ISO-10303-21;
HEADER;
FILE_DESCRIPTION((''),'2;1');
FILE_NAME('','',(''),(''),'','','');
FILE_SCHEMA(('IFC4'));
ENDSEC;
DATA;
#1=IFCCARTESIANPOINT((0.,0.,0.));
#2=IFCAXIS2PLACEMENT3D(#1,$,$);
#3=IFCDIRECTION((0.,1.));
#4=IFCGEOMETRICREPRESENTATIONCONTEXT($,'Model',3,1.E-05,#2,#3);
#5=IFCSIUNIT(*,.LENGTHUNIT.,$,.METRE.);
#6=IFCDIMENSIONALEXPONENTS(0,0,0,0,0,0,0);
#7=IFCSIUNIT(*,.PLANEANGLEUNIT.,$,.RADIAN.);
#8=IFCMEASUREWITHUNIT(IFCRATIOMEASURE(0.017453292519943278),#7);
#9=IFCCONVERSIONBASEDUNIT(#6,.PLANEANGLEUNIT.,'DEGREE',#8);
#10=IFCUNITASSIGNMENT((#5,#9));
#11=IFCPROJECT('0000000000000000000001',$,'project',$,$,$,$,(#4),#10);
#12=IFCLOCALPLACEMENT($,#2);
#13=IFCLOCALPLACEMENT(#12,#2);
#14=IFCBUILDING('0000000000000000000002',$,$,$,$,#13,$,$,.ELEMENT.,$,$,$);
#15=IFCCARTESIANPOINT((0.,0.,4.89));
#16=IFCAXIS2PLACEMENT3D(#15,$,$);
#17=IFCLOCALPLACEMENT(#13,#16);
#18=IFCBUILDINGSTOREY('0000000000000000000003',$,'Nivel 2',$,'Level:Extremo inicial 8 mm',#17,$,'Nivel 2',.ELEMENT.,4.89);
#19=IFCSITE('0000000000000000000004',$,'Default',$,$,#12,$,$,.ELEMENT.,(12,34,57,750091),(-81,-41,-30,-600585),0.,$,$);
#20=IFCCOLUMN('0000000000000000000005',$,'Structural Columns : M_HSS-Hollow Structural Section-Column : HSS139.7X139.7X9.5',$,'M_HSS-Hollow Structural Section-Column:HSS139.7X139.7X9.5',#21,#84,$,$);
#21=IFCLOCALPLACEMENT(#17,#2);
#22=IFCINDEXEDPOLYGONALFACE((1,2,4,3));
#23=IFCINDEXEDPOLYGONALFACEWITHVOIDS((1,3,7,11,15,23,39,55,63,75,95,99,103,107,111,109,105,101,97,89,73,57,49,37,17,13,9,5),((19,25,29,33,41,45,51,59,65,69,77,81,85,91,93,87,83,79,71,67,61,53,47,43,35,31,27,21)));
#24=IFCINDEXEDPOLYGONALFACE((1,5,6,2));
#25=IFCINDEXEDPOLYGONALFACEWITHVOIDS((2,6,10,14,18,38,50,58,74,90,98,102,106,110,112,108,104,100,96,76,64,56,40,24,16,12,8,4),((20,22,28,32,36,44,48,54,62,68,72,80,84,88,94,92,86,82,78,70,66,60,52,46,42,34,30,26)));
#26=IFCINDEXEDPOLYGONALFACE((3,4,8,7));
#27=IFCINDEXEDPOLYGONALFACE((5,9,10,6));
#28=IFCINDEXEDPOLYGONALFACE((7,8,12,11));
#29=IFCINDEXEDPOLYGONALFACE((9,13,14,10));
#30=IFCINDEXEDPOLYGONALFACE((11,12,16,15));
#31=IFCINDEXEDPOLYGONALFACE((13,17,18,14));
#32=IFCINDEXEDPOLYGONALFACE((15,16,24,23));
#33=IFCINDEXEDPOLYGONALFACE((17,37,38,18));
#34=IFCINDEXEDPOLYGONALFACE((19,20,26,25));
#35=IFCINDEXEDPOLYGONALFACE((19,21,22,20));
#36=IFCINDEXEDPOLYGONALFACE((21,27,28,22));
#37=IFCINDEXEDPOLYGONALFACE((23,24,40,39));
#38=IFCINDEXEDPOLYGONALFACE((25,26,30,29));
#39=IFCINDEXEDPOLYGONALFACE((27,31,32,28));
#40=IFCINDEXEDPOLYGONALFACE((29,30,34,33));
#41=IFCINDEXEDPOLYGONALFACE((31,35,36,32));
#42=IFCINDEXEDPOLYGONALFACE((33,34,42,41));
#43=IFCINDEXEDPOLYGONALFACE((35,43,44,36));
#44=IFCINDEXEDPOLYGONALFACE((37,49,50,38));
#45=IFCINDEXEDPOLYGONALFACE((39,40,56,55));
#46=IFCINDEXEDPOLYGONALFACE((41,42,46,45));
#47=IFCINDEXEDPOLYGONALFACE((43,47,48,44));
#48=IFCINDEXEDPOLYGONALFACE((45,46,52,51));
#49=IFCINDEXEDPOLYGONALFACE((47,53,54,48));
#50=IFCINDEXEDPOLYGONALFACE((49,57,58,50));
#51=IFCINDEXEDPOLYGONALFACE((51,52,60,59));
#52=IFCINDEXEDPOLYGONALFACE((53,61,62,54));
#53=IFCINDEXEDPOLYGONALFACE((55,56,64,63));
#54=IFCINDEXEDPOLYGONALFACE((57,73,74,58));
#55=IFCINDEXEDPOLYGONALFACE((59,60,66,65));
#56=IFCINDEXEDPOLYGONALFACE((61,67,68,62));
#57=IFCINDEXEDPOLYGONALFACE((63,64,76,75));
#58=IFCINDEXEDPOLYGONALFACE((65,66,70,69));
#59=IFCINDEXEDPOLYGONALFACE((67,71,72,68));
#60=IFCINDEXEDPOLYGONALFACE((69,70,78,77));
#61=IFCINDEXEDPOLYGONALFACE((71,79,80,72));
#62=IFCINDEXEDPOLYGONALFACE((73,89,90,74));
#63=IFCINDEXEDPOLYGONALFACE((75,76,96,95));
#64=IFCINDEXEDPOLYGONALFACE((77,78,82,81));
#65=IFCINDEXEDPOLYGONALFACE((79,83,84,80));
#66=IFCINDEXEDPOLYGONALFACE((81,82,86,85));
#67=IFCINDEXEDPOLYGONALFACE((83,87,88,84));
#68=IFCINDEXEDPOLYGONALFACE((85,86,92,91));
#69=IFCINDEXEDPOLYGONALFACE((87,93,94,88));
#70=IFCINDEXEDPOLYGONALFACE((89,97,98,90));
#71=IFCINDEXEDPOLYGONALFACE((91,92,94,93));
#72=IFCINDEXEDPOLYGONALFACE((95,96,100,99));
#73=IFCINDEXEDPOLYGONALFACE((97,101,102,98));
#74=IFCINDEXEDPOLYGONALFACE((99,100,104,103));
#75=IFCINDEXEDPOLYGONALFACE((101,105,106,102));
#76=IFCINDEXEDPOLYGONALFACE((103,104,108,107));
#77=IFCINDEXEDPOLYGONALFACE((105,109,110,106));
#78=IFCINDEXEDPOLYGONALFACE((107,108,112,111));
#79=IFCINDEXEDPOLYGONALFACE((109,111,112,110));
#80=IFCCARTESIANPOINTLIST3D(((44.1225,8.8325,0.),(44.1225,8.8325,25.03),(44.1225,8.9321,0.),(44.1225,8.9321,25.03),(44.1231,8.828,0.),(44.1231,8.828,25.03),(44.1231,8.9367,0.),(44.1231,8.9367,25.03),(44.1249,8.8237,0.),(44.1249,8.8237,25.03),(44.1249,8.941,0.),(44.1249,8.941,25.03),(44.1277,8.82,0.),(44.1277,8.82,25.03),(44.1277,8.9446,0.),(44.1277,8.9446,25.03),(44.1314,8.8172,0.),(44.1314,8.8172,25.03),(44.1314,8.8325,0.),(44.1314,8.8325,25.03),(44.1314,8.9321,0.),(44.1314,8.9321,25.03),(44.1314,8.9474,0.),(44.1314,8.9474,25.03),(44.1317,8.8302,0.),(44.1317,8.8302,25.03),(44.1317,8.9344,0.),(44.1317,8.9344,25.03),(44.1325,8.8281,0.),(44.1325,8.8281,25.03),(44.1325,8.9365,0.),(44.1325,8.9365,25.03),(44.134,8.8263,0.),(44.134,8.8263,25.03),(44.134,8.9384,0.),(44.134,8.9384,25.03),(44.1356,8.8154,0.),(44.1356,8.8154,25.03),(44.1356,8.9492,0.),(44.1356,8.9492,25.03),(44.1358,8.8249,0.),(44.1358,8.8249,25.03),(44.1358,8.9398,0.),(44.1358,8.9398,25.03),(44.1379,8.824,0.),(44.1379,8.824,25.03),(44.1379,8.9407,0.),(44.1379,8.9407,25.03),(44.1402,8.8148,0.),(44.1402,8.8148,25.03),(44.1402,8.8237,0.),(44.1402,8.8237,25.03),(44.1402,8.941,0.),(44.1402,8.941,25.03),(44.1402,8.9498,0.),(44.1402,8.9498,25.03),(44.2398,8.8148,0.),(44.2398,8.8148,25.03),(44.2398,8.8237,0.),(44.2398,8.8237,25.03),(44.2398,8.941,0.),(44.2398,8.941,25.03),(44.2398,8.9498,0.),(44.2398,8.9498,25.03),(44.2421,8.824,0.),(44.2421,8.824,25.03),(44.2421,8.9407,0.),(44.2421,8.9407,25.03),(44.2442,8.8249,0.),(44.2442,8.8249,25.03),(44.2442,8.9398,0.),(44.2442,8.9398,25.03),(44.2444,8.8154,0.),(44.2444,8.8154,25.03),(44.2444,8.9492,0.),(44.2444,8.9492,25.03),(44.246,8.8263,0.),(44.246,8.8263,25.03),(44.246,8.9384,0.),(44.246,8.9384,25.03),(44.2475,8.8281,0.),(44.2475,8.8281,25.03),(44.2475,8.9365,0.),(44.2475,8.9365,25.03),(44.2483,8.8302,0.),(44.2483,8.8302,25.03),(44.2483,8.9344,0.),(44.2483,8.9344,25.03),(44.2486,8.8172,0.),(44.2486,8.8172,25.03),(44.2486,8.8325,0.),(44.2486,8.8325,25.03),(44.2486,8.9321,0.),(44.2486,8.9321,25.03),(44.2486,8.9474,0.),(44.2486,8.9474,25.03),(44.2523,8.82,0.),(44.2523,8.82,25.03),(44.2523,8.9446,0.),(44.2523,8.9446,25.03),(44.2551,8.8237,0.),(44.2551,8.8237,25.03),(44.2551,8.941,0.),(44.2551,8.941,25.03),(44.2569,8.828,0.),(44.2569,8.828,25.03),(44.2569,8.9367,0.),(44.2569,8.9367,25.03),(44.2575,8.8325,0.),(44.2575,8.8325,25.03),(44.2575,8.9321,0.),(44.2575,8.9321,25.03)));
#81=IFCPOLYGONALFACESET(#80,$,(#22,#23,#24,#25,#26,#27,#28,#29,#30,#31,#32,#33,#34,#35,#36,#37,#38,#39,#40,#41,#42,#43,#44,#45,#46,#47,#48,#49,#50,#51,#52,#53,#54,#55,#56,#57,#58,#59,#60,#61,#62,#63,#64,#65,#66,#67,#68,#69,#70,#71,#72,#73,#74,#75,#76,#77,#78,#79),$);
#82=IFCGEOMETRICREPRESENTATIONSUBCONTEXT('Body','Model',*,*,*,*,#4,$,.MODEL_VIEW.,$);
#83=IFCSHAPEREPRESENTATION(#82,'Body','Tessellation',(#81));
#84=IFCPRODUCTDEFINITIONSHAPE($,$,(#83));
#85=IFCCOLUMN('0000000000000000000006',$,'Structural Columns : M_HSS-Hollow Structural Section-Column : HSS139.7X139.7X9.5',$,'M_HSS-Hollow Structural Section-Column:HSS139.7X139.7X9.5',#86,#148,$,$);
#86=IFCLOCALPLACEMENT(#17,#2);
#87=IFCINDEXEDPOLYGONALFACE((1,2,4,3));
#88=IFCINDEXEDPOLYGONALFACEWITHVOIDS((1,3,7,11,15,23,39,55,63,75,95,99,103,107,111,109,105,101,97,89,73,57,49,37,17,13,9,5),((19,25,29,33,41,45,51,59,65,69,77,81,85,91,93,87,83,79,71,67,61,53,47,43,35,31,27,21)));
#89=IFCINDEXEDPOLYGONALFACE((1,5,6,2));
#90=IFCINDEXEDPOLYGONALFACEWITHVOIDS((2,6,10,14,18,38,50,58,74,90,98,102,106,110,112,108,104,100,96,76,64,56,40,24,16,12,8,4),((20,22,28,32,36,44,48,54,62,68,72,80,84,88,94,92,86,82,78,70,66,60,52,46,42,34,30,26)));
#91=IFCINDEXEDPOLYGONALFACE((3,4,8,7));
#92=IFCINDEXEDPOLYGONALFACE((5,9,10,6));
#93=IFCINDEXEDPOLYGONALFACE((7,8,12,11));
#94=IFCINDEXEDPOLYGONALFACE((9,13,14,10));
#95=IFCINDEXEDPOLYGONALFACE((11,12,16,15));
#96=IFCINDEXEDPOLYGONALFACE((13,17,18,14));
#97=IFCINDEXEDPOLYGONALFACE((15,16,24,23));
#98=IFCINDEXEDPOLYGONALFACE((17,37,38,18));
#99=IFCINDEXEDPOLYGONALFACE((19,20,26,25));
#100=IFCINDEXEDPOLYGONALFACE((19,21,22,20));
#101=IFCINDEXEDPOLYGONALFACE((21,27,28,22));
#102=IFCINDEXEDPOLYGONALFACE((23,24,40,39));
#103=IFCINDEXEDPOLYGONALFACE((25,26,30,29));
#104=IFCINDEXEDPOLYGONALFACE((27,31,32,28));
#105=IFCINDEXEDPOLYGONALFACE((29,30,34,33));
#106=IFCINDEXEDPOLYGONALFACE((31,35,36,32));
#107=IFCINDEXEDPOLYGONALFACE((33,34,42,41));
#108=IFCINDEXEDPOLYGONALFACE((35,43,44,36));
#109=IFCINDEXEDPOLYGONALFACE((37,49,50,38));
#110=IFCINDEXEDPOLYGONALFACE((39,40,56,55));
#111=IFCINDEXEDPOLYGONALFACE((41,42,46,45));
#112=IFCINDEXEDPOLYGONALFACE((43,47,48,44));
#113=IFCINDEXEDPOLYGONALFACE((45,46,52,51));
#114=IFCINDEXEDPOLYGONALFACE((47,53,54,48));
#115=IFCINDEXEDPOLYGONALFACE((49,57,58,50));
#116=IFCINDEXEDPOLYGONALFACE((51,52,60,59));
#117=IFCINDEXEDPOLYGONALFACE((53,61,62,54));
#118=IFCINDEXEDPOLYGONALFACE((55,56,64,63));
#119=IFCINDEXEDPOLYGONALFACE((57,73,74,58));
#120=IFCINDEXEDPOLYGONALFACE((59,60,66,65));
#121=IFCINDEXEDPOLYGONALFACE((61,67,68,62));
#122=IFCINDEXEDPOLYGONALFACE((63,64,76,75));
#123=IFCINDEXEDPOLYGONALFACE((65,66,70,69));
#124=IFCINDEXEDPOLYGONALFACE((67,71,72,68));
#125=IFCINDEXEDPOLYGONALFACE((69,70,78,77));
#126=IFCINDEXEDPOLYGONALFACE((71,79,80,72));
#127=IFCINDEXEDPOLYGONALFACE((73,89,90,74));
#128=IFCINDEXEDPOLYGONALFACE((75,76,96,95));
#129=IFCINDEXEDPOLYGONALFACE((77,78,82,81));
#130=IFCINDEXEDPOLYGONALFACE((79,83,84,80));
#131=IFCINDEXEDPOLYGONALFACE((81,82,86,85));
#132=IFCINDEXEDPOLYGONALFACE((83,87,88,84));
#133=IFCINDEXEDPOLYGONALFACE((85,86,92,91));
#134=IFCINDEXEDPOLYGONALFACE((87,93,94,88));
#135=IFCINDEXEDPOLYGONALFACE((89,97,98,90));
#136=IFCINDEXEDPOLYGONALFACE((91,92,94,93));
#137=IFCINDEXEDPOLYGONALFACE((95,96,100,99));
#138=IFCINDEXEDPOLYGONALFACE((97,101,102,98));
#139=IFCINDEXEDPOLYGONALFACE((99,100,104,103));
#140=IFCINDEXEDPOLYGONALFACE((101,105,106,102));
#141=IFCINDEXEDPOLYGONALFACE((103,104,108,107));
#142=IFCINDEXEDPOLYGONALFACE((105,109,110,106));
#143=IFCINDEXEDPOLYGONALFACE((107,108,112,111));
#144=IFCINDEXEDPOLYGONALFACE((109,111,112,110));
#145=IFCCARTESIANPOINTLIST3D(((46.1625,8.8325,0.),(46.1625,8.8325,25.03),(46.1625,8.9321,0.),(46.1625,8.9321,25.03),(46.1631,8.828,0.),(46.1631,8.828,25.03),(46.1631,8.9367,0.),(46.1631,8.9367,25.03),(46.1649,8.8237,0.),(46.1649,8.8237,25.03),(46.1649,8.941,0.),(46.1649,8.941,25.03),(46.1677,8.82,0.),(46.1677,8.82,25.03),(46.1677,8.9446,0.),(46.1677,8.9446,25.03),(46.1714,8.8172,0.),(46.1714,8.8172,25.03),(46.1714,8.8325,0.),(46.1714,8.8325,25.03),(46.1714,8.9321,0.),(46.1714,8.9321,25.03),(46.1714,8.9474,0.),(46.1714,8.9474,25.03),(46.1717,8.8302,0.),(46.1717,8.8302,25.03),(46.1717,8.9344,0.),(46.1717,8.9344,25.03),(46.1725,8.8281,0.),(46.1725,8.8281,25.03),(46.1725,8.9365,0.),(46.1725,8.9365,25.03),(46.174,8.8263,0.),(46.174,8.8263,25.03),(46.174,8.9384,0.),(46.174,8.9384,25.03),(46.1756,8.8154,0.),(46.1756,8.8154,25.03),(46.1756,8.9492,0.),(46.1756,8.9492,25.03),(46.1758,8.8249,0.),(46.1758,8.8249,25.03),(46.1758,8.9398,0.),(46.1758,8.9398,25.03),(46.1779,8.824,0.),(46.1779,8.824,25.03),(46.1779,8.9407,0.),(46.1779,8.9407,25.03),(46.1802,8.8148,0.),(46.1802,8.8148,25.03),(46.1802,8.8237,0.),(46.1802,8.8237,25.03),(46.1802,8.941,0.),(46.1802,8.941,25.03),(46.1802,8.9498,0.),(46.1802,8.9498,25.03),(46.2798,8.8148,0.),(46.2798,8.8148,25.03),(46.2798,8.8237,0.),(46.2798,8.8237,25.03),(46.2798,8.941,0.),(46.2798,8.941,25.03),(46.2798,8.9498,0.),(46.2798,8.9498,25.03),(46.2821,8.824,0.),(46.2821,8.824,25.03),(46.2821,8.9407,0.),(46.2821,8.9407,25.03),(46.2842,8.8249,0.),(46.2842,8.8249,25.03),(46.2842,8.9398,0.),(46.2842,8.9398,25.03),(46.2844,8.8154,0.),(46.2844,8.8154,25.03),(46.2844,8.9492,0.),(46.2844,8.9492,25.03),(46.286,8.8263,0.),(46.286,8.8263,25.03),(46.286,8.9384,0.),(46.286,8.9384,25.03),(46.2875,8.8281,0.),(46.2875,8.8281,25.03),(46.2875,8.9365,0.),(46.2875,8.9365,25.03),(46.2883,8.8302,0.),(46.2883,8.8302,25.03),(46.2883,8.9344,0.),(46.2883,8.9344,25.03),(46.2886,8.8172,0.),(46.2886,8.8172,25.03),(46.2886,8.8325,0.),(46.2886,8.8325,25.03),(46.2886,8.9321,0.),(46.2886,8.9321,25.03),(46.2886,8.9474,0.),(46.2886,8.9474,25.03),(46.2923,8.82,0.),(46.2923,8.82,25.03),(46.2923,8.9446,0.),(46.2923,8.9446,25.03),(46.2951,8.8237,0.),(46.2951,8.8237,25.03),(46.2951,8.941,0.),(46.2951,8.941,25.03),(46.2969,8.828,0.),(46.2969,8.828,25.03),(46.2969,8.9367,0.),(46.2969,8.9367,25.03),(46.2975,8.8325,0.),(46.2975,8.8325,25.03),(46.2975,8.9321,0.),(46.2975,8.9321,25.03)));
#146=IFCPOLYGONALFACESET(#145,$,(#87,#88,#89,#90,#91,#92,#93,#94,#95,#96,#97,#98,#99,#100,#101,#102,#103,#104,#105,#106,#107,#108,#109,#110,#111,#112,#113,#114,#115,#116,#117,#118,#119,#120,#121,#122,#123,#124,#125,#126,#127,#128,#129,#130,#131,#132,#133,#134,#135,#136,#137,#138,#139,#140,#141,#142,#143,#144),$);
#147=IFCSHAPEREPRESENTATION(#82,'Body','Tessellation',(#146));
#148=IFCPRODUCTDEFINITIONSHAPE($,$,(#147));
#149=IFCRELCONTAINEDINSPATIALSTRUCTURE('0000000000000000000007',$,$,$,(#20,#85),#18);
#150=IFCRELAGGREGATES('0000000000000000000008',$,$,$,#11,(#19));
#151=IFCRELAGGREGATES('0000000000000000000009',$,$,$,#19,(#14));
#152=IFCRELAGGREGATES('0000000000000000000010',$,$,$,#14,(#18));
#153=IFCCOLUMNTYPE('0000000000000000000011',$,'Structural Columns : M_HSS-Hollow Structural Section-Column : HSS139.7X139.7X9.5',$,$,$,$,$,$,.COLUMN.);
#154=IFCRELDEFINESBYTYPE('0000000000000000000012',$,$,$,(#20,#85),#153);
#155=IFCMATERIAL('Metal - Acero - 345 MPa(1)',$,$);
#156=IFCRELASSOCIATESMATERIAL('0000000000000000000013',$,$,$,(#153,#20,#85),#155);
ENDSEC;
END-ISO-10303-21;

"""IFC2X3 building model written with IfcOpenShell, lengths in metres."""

from ifc_helpers import new_model, entity, si_unit, converted_unit, direction, frame, frame_2d, origin, place, context, subcontext, project, spatial, polyline, circle_curve, parameter, trimmed, segment, composite_curve, outline, extrude, source, transform, mapped, material, type_object, type_shapes, element, save


model = new_model("IFC2X3")

# Units and contexts
model_context = context("Model", 3, precision=1e-05, world=origin(), true_north=direction((0.0, 1.0)))
body_context = subcontext(model_context, "Body", "Model", "MODEL_VIEW")
ifc_project = project(units=[si_unit("LENGTHUNIT", "METRE"), converted_unit("PLANEANGLEUNIT", "DEGREE", entity("IfcRatioMeasure", 0.017453292519943278), si_unit("PLANEANGLEUNIT", "RADIAN"), dimensions=[0, 0, 0, 0, 0, 0, 0])], contexts=[model_context])

# Site, building, storey
site_placement = place(None, origin())
site = spatial("IfcSite", under=ifc_project, at=site_placement, Name="Default", CompositionType="ELEMENT", RefLatitude=(12, 34, 57, 750091), RefLongitude=(-81, -41, -30, -600585), RefElevation=0.0)
building_placement = place(site_placement, origin())
building = spatial("IfcBuilding", under=site, at=building_placement, CompositionType="ELEMENT")
storey_placement = place(building_placement, frame((0.0, 0.0, 4.89)))
storey = spatial("IfcBuildingStorey", under=building, at=storey_placement, Name="Nivel 2", ObjectType="Level:Extremo inicial 8 mm", LongName="Nivel 2", CompositionType="ELEMENT", Elevation=4.89)

# Columns
ifc_material_1 = material(Name="Metal - Acero - 345 MPa(1)")
column_type_1 = type_object("IfcColumnType", Name="Structural Columns : M_HSS-Hollow Structural Section-Column : HSS139.7X139.7X9.5", PredefinedType="COLUMN", material=ifc_material_1)
shared_shape_1 = source(origin(), body_context, "Body", "SweptSolid", [
    extrude(outline(composite_curve([segment(polyline([(-0.0498, -0.0675), (0.0498, -0.0675)]), True, "CONTINUOUS"), segment(trimmed(circle_curve(frame_2d((0.0498, -0.0498), x_axis=(-1.0, 0.0)), 0.0177), [parameter(90.0)], [parameter(180.0)], True, "PARAMETER"), True, "CONTINUOUS"), segment(polyline([(0.0675, -0.0498), (0.0675, 0.0498)]), True, "CONTINUOUS"), segment(trimmed(circle_curve(frame_2d((0.0498, 0.0498), x_axis=(-1.0, 0.0)), 0.0177), [parameter(180.0)], [parameter(270.0)], True, "PARAMETER"), True, "CONTINUOUS"), segment(polyline([(0.0498, 0.0675), (-0.0498, 0.0675)]), True, "CONTINUOUS"), segment(trimmed(circle_curve(frame_2d((-0.0498, 0.0498), x_axis=(-1.0, 0.0)), 0.0177), [parameter(270.0)], [parameter(360.0)], True, "PARAMETER"), True, "CONTINUOUS"), segment(polyline([(-0.0675, 0.0498), (-0.0675, -0.0498)]), True, "CONTINUOUS"), segment(trimmed(circle_curve(frame_2d((-0.0498, -0.0498), x_axis=(-1.0, 0.0)), 0.0177), [parameter(360.0)], [parameter(90.0)], True, "PARAMETER"), True, "CONTINUOUS")], self_intersect=False), holes=[composite_curve([segment(trimmed(circle_curve(frame_2d((-0.0498, -0.0498), x_axis=(-1.0, 0.0)), 0.0089), [parameter(0.0)], [parameter(90.0)], True, "PARAMETER"), False, "CONTINUOUS"), segment(polyline([(-0.0586, -0.0498), (-0.0586, 0.0498)]), True, "CONTINUOUS"), segment(trimmed(circle_curve(frame_2d((-0.0498, 0.0498), x_axis=(-1.0, 0.0)), 0.0089), [parameter(270.0)], [parameter(0.0)], True, "PARAMETER"), False, "CONTINUOUS"), segment(polyline([(-0.0498, 0.0586), (0.0498, 0.0586)]), True, "CONTINUOUS"), segment(trimmed(circle_curve(frame_2d((0.0498, 0.0498), x_axis=(-1.0, 0.0)), 0.0089), [parameter(180.0)], [parameter(270.0)], True, "PARAMETER"), False, "CONTINUOUS"), segment(polyline([(0.0586, 0.0498), (0.0586, -0.0498)]), True, "CONTINUOUS"), segment(trimmed(circle_curve(frame_2d((0.0498, -0.0498), x_axis=(-1.0, 0.0)), 0.0089), [parameter(90.0)], [parameter(180.0)], True, "PARAMETER"), False, "CONTINUOUS"), segment(polyline([(0.0498, -0.0586), (-0.0498, -0.0586)]), True, "CONTINUOUS")], self_intersect=False)]), frame((0.0, 0.0, 4.89), z_axis=(0.0, 0.0, 1.0), x_axis=(-1.0, 0.0, 0.0)), (0.0, 0.0, 1.0), 25.03),
])
type_shapes(column_type_1, [shared_shape_1])
for number, where, name in (
    (1, (44.19, 8.8823, -4.89), "Structural Columns : M_HSS-Hollow Structural Section-Column : HSS139.7X139.7X9.5"),
    (2, (46.23, 8.8823, -4.89), "Structural Columns : M_HSS-Hollow Structural Section-Column : HSS139.7X139.7X9.5"),
):
    element("IfcColumn", number, at=place(storey_placement, frame(where)), inside=storey, type_object=column_type_1, material=ifc_material_1, Name=name, ObjectType="M_HSS-Hollow Structural Section-Column:HSS139.7X139.7X9.5", context=body_context, shape_type="MappedRepresentation", body=[
        mapped(shared_shape_1, transform((0.0, 0.0, 0.0), scale=1.0)),
    ])

save(model, "model.ifc")
